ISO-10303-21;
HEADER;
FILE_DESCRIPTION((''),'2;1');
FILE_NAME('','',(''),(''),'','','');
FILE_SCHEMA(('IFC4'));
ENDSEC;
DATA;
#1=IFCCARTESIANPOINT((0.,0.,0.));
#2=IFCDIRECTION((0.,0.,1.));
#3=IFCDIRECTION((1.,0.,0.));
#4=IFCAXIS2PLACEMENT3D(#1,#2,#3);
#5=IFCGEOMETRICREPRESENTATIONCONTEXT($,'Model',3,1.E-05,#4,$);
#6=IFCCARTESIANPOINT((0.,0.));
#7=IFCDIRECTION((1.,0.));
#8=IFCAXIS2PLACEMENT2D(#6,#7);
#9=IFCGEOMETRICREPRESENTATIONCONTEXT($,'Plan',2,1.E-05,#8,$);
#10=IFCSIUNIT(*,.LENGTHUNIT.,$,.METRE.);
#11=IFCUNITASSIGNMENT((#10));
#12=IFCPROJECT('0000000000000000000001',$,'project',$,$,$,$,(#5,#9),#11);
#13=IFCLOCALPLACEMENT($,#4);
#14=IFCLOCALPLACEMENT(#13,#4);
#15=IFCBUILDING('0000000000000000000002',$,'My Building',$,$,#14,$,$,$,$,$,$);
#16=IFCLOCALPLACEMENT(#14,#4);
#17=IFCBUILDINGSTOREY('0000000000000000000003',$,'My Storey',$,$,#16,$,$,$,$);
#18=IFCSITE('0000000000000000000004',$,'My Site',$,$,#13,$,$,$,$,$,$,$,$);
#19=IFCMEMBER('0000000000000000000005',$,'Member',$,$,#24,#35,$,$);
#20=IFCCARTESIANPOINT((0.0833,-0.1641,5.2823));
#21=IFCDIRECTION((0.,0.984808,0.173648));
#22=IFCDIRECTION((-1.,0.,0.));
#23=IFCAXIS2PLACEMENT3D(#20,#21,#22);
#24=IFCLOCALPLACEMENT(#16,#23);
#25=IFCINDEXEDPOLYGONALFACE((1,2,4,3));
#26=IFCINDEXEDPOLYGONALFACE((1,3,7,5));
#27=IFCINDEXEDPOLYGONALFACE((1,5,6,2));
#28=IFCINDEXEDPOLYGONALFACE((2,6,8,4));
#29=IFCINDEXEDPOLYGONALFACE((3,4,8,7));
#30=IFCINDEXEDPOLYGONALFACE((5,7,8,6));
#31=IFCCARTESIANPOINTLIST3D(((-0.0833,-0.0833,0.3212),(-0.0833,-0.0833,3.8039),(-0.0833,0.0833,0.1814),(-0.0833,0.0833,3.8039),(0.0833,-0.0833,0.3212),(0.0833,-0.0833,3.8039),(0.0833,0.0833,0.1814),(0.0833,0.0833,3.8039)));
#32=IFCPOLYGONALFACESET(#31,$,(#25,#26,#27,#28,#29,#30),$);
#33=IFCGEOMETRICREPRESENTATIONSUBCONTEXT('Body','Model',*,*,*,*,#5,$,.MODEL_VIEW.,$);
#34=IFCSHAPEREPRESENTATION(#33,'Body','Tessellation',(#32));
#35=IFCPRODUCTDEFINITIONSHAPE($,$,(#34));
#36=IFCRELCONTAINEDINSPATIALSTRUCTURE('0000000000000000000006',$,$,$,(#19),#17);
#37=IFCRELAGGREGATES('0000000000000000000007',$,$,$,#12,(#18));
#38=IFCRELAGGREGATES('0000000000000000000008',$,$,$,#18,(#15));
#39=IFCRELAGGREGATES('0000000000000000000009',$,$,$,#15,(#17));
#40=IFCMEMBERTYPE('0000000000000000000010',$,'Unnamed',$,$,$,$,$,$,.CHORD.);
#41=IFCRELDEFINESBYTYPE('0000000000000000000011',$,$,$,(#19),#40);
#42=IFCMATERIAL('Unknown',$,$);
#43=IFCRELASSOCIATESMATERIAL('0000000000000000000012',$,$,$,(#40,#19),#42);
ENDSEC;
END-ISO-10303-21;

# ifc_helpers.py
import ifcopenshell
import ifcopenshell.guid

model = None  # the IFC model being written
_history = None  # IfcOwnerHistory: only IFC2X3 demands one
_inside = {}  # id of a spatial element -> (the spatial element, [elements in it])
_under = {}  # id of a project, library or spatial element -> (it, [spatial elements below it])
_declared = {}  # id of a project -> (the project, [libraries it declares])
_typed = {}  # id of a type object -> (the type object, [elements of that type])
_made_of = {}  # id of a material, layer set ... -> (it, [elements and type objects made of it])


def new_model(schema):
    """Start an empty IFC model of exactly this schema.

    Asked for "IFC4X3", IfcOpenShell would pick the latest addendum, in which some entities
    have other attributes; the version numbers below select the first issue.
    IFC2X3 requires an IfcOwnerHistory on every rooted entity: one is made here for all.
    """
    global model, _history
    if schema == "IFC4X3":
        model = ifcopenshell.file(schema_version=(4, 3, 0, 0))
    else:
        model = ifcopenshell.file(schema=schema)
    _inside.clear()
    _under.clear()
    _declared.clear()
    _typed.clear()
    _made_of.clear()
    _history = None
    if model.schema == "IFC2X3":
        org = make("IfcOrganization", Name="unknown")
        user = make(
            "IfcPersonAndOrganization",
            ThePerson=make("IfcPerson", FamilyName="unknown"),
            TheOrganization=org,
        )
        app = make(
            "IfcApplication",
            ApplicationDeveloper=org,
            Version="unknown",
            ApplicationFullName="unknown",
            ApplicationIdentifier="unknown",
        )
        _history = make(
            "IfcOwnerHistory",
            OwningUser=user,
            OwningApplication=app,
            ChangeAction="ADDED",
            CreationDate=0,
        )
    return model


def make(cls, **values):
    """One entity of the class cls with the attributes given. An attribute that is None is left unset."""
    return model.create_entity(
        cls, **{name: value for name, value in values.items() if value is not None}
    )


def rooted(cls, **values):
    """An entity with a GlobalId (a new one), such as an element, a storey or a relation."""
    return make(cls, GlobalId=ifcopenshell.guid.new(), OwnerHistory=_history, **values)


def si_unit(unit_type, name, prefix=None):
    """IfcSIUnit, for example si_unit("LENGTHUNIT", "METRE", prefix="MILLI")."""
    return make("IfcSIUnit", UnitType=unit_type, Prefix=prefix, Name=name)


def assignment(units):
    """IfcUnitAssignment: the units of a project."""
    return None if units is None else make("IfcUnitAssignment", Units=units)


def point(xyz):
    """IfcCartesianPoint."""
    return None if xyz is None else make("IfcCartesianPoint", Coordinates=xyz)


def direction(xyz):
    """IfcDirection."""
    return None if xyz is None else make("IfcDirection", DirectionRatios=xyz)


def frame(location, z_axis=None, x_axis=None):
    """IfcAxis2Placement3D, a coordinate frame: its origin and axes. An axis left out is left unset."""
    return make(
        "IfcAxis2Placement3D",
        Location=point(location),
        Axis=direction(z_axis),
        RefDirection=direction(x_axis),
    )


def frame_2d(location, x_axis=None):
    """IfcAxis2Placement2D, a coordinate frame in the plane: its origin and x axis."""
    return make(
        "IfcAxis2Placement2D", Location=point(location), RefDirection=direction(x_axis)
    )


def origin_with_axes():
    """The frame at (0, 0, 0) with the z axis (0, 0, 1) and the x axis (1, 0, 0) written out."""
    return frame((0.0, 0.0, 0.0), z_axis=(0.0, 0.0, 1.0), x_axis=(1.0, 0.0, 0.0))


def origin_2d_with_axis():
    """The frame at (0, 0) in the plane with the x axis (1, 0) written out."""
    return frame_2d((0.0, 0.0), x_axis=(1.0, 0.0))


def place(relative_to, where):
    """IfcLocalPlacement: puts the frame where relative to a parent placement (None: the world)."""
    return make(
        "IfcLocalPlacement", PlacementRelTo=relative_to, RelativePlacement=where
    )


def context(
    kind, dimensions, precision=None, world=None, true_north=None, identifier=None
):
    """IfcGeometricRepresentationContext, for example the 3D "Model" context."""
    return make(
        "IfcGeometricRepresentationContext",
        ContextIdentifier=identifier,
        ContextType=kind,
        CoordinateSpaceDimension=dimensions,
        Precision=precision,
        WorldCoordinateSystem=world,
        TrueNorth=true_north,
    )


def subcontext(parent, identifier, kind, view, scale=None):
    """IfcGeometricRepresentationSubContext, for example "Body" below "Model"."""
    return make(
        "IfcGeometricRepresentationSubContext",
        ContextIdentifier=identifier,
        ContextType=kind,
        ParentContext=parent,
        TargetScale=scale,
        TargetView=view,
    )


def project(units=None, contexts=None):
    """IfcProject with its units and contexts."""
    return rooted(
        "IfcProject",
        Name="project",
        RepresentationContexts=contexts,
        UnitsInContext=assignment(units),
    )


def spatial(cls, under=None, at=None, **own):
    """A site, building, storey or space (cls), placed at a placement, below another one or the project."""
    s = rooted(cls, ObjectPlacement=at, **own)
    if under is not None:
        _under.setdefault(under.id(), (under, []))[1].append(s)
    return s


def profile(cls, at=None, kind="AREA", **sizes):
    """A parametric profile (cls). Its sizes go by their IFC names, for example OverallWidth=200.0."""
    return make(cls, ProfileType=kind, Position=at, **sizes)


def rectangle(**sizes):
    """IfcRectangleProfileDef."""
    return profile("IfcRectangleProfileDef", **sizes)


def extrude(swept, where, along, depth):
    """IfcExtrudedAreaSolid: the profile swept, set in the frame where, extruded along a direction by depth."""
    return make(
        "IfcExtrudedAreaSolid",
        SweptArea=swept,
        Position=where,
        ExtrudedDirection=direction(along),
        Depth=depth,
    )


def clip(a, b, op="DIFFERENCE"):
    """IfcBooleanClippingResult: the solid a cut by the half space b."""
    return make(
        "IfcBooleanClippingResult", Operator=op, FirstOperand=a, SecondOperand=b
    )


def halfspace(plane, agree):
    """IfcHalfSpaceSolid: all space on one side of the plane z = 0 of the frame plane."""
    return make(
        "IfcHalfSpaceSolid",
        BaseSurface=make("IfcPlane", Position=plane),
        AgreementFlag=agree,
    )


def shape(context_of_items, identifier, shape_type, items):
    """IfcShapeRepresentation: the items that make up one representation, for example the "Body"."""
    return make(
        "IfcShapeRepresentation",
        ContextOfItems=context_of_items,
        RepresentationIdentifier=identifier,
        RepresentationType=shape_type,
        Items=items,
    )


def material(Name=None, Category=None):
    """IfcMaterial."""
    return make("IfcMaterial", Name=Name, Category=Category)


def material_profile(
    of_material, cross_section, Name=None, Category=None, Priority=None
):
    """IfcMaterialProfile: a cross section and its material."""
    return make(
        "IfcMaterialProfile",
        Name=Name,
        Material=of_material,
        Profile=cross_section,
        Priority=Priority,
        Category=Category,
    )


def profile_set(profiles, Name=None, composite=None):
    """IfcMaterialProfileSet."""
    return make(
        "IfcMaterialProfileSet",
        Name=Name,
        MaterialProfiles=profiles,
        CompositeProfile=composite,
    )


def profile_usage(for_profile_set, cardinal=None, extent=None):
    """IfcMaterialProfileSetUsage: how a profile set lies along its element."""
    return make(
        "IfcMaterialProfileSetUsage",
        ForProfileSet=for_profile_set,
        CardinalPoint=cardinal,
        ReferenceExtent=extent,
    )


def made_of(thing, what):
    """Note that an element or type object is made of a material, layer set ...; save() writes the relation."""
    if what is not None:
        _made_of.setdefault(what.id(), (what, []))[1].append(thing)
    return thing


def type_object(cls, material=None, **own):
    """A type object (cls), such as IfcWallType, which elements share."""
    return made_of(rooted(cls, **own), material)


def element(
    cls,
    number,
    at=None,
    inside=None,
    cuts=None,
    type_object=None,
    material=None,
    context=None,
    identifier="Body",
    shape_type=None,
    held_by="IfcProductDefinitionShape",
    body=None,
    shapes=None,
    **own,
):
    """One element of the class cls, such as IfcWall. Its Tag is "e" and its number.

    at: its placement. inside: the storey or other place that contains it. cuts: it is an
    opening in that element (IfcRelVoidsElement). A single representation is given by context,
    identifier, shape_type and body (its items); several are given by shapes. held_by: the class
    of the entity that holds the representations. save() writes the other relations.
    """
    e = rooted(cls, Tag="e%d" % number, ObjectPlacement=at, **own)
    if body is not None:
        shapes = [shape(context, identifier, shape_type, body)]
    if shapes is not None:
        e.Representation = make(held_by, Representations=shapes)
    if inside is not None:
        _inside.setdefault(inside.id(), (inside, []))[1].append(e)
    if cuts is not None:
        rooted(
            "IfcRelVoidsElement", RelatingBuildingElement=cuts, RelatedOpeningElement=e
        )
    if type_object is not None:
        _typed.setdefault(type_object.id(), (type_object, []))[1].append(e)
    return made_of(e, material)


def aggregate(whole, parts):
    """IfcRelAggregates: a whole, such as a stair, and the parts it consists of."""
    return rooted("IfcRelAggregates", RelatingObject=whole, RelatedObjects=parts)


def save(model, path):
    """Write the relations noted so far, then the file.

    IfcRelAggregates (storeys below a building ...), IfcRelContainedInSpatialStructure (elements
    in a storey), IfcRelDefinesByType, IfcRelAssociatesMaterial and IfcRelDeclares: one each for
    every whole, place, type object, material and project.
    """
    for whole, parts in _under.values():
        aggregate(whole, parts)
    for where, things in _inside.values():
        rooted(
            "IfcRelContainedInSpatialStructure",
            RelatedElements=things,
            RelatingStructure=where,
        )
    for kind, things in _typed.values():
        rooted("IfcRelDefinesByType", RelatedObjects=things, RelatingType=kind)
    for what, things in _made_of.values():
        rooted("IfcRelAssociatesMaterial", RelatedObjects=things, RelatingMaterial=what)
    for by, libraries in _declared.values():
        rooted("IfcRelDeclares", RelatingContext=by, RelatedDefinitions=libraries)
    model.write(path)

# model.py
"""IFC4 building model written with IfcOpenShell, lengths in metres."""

from ifc_helpers import new_model, si_unit, frame, origin_with_axes, origin_2d_with_axis, place, context, subcontext, project, spatial, rectangle, extrude, clip, halfspace, material, material_profile, profile_set, profile_usage, type_object, element, save


model = new_model("IFC4")

# Units and contexts
model_context = context("Model", 3, precision=1e-05, world=origin_with_axes())
plan_context = context("Plan", 2, precision=1e-05, world=origin_2d_with_axis())
body_context = subcontext(model_context, "Body", "Model", "MODEL_VIEW")
ifc_project = project(units=[si_unit("LENGTHUNIT", "METRE")], contexts=[model_context, plan_context])

# Site, building, storey
site_placement = place(None, origin_with_axes())
site = spatial("IfcSite", under=ifc_project, at=site_placement, Name="My Site")
building_placement = place(site_placement, origin_with_axes())
building = spatial("IfcBuilding", under=site, at=building_placement, Name="My Building")
storey_placement = place(building_placement, origin_with_axes())
storey = spatial("IfcBuildingStorey", under=building, at=storey_placement, Name="My Storey")

# Shared definitions
ifc_material = material(Name="Unknown")

# Member
ifc_material_profile_1 = material_profile(ifc_material, rectangle(XDim=0.1667, YDim=0.1667))
ifc_profile_set_1 = profile_set([ifc_material_profile_1])
member_type = type_object("IfcMemberType", Name="Unnamed", PredefinedType="CHORD", material=ifc_profile_set_1)
ifc_profile_usage_1 = profile_usage(ifc_profile_set_1, cardinal=5)
member_1_placement = place(storey_placement, frame((0.0833, -0.1641, 5.2823), z_axis=(0.0, 0.984808, 0.173648), x_axis=(-1.0, 0.0, 0.0)))
element("IfcMember", 1, at=member_1_placement, inside=storey, type_object=member_type, material=ifc_profile_usage_1, Name="Member", context=body_context, shape_type="Clipping", body=[
    clip(extrude(rectangle(XDim=0.1667, YDim=0.1667), origin_with_axes(), (0.0, 0.0, 1.0), 3.8039), halfspace(frame((1.4167, 0.0833, 0.1814), z_axis=(0.0, -0.642788, -0.766044), x_axis=(-1.0, 0.0, 0.0)), False)),
])

save(model, "model.ifc")
